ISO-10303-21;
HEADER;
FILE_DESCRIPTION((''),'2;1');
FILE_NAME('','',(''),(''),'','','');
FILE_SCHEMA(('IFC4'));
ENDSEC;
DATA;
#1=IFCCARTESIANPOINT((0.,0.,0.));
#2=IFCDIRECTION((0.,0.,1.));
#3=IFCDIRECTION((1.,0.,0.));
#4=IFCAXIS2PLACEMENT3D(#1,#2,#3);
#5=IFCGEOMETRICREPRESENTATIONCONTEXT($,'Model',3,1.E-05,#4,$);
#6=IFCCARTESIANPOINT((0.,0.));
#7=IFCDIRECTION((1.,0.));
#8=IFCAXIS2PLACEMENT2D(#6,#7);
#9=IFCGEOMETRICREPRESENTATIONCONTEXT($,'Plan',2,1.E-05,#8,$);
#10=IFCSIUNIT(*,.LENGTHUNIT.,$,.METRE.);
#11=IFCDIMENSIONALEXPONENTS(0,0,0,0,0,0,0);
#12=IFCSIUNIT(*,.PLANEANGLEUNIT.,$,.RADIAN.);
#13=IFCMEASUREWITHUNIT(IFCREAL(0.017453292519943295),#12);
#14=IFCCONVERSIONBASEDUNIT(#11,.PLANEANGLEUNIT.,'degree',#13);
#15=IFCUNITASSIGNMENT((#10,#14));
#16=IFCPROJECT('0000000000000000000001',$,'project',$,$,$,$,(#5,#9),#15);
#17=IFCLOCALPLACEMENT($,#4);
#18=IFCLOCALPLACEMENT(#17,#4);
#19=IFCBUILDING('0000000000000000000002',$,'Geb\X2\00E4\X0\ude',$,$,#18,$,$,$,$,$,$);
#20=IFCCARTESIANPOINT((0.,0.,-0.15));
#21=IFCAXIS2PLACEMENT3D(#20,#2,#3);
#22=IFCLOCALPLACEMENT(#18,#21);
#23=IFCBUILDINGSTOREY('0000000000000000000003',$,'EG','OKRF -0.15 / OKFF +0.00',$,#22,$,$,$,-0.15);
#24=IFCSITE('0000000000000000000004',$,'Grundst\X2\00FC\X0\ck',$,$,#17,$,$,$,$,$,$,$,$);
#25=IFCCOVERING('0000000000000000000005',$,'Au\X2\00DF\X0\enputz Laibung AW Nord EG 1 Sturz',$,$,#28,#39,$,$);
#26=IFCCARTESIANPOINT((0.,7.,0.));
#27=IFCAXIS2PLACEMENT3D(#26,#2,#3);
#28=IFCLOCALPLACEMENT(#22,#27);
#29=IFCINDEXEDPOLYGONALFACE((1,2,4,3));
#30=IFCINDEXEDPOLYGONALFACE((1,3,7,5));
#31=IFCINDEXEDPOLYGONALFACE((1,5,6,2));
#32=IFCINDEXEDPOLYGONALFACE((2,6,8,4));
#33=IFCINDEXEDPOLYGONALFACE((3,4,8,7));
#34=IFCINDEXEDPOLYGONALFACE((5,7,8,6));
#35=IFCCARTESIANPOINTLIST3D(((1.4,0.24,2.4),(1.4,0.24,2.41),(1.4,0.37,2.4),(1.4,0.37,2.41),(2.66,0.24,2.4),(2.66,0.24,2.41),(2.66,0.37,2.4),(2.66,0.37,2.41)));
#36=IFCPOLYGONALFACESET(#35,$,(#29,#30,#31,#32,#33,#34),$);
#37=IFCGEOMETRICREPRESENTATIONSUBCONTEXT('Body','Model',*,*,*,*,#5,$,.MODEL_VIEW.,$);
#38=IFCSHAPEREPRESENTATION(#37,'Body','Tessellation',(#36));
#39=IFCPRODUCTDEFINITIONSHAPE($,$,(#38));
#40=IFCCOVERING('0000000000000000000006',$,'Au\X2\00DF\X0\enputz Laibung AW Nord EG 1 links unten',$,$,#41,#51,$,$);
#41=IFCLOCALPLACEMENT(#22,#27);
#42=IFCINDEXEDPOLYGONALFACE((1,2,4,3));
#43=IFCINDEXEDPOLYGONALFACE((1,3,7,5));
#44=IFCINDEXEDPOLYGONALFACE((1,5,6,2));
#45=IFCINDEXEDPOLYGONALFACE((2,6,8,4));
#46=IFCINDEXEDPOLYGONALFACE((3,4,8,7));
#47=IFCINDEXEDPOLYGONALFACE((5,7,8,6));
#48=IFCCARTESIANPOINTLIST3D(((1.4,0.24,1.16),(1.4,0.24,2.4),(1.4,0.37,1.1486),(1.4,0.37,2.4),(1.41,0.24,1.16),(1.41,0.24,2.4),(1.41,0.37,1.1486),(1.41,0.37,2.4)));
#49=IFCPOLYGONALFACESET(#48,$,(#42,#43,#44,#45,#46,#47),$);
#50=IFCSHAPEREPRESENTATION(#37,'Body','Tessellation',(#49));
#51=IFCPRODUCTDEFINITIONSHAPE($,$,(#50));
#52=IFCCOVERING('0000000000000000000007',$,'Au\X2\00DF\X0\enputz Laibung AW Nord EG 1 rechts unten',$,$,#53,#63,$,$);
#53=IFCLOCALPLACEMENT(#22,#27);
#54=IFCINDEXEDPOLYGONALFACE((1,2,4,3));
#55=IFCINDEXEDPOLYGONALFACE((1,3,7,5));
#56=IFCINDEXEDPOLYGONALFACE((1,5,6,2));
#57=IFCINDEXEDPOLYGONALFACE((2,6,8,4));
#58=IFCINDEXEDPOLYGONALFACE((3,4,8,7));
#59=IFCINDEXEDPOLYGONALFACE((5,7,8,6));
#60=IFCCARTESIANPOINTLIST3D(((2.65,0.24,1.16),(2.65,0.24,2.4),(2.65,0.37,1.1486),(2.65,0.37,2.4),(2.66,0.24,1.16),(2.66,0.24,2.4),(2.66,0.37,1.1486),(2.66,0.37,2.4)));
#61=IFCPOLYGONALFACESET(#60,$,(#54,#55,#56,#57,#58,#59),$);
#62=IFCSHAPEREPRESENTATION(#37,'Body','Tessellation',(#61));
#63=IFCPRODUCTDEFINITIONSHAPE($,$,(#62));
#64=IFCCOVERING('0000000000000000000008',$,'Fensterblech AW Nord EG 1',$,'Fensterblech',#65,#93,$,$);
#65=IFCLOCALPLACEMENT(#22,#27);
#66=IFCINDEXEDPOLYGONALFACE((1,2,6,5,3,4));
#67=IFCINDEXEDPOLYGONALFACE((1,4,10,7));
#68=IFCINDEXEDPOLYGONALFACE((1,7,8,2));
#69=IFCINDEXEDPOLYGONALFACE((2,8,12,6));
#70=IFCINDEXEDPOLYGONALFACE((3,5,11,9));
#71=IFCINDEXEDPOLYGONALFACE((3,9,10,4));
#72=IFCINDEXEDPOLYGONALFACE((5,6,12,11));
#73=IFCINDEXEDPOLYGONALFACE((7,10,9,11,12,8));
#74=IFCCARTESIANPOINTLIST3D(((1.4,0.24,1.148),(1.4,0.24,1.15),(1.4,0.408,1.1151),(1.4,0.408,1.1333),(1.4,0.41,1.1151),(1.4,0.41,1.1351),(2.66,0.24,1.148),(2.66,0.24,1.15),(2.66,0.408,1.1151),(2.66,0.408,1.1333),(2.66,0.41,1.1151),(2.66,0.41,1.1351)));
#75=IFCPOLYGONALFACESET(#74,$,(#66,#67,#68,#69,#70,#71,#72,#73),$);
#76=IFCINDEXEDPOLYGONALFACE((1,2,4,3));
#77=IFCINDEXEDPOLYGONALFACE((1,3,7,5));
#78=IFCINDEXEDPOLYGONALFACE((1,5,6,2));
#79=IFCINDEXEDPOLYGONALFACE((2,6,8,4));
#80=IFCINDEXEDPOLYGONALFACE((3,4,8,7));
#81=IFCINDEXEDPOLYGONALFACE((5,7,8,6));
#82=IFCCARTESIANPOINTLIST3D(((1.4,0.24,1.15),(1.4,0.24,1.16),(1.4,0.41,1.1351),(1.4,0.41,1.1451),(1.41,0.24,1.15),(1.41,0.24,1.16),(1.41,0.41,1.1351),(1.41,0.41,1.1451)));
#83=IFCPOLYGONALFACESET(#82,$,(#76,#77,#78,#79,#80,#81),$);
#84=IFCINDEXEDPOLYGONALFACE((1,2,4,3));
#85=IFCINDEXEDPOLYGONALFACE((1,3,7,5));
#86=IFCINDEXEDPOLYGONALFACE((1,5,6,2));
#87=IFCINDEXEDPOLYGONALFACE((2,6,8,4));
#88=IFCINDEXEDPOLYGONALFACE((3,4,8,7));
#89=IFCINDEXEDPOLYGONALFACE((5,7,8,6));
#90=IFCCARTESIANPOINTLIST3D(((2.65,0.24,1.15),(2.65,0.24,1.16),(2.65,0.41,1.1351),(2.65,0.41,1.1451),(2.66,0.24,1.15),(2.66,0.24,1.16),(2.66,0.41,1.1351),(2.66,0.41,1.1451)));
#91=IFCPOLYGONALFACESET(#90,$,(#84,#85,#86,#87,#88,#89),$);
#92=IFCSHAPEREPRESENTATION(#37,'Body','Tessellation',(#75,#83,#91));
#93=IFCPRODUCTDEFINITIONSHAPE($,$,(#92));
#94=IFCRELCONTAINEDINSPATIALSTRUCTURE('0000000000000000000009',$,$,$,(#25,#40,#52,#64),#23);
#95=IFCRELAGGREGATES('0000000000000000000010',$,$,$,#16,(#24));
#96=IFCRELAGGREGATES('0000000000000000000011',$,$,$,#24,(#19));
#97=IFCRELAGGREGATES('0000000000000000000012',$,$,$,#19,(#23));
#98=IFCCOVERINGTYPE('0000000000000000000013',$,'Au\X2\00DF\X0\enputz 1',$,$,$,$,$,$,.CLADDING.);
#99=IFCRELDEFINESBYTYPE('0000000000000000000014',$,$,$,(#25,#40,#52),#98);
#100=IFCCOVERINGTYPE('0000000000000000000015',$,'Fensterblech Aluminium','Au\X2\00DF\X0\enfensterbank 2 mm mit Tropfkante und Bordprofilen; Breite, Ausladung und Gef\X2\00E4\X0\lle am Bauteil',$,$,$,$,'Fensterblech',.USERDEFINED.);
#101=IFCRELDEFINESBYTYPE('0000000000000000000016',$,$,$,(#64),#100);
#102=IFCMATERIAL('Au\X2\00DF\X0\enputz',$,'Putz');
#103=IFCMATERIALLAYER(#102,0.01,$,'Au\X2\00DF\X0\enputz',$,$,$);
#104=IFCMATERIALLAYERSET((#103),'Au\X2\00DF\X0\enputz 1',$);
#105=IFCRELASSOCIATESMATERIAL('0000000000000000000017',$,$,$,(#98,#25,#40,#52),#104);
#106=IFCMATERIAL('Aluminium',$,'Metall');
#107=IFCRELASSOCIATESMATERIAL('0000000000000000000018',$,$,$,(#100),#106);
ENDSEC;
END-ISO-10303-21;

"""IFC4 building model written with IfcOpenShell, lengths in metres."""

from ifc_helpers import new_model, entity, si_unit, converted_unit, frame, origin_with_axes, origin_2d_with_axis, place, context, subcontext, project, spatial, polyline, outline, extrude, material, layer, layer_set, layer_usage, type_object, element, save


model = new_model("IFC4")

# Units and contexts
model_context = context("Model", 3, precision=1e-05, world=origin_with_axes())
plan_context = context("Plan", 2, precision=1e-05, world=origin_2d_with_axis())
body_context_1 = subcontext(model_context, "Body", "Model", "MODEL_VIEW")
ifc_project = project(units=[si_unit("LENGTHUNIT", "METRE"), converted_unit("PLANEANGLEUNIT", "degree", entity("IfcReal", 0.017453292519943295), si_unit("PLANEANGLEUNIT", "RADIAN"), dimensions=[0, 0, 0, 0, 0, 0, 0])], contexts=[model_context, plan_context])

# Site, building, storey
site_placement = place(None, origin_with_axes())
site = spatial("IfcSite", under=ifc_project, at=site_placement, Name="Grundstück")
building_placement = place(site_placement, origin_with_axes())
building = spatial("IfcBuilding", under=site, at=building_placement, Name="Gebäude")
storey_placement = place(building_placement, frame((0.0, 0.0, -0.15), z_axis=(0.0, 0.0, 1.0), x_axis=(1.0, 0.0, 0.0)))
storey = spatial("IfcBuildingStorey", under=building, at=storey_placement, Name="EG", Description="OKRF -0.15 / OKFF +0.00", Elevation=-0.15)

# Coverings
ifc_material_1 = material(Name="Außenputz", Category="Putz")
ifc_layer_1 = layer(ifc_material_1, 0.01, Name="Außenputz")
ifc_layer_set_1 = layer_set([ifc_layer_1], Name="Außenputz 1")
ifc_layer_usage_1 = layer_usage(ifc_layer_set_1, "AXIS3", "POSITIVE", 2.4)
covering_type_1 = type_object("IfcCoveringType", Name="Außenputz 1", PredefinedType="CLADDING", material=ifc_layer_set_1)
covering_1_placement = place(storey_placement, frame((0.0, 7.0, 0.0), z_axis=(0.0, 0.0, 1.0), x_axis=(1.0, 0.0, 0.0)))
element("IfcCovering", 1, at=covering_1_placement, inside=storey, type_object=covering_type_1, material=ifc_layer_usage_1, Name="Außenputz Laibung AW Nord EG 1 Sturz", context=body_context_1, shape_type="SweptSolid", body=[
    extrude(outline(polyline([(0.24, 2.4), (0.37, 2.4), (0.37, 2.41), (0.24, 2.41), (0.24, 2.4)])), frame((1.4, 0.0, 0.0), z_axis=(1.0, 0.0, 0.0), x_axis=(0.0, 1.0, 0.0)), (0.0, 0.0, 1.0), 1.26),
])
ifc_layer_usage_2 = layer_usage(ifc_layer_set_1, "AXIS1", "POSITIVE", 1.4)
covering_2_placement = place(storey_placement, frame((0.0, 7.0, 0.0), z_axis=(0.0, 0.0, 1.0), x_axis=(1.0, 0.0, 0.0)))
element("IfcCovering", 2, at=covering_2_placement, inside=storey, type_object=covering_type_1, material=ifc_layer_usage_2, Name="Außenputz Laibung AW Nord EG 1 links unten", context=body_context_1, shape_type="SweptSolid", body=[
    extrude(outline(polyline([(0.24, 1.16), (0.37, 1.1486), (0.37, 2.4), (0.24, 2.4), (0.24, 1.16)])), frame((1.4, 0.0, 0.0), z_axis=(1.0, 0.0, 0.0), x_axis=(0.0, 1.0, 0.0)), (0.0, 0.0, 1.0), 0.01),
])
ifc_layer_usage_3 = layer_usage(ifc_layer_set_1, "AXIS1", "POSITIVE", 2.65)
covering_3_placement = place(storey_placement, frame((0.0, 7.0, 0.0), z_axis=(0.0, 0.0, 1.0), x_axis=(1.0, 0.0, 0.0)))
element("IfcCovering", 3, at=covering_3_placement, inside=storey, type_object=covering_type_1, material=ifc_layer_usage_3, Name="Außenputz Laibung AW Nord EG 1 rechts unten", context=body_context_1, shape_type="SweptSolid", body=[
    extrude(outline(polyline([(0.24, 1.16), (0.37, 1.1486), (0.37, 2.4), (0.24, 2.4), (0.24, 1.16)])), frame((2.65, 0.0, 0.0), z_axis=(1.0, 0.0, 0.0), x_axis=(0.0, 1.0, 0.0)), (0.0, 0.0, 1.0), 0.01),
])

# Covering
ifc_material_2 = material(Name="Aluminium", Category="Metall")
covering_type_2 = type_object("IfcCoveringType", Name="Fensterblech Aluminium", Description="Außenfensterbank 2 mm mit Tropfkante und Bordprofilen; Breite, Ausladung und Gefälle am Bauteil", ElementType="Fensterblech", PredefinedType="USERDEFINED", material=ifc_material_2)
covering_4_placement = place(storey_placement, frame((0.0, 7.0, 0.0), z_axis=(0.0, 0.0, 1.0), x_axis=(1.0, 0.0, 0.0)))
element("IfcCovering", 4, at=covering_4_placement, inside=storey, type_object=covering_type_2, Name="Fensterblech AW Nord EG 1", ObjectType="Fensterblech", context=body_context_1, shape_type="SweptSolid", body=[
    extrude(outline(polyline([(0.24, 1.148), (0.408, 1.1333), (0.408, 1.1151), (0.41, 1.1151), (0.41, 1.1351), (0.24, 1.15), (0.24, 1.148)])), frame((1.4, 0.0, 0.0), z_axis=(1.0, 0.0, 0.0), x_axis=(0.0, 1.0, 0.0)), (0.0, 0.0, 1.0), 1.26),
    extrude(outline(polyline([(0.24, 1.15), (0.41, 1.1351), (0.41, 1.1451), (0.24, 1.16), (0.24, 1.15)])), frame((1.4, 0.0, 0.0), z_axis=(1.0, 0.0, 0.0), x_axis=(0.0, 1.0, 0.0)), (0.0, 0.0, 1.0), 0.01),
    extrude(outline(polyline([(0.24, 1.15), (0.41, 1.1351), (0.41, 1.1451), (0.24, 1.16), (0.24, 1.15)])), frame((2.65, 0.0, 0.0), z_axis=(1.0, 0.0, 0.0), x_axis=(0.0, 1.0, 0.0)), (0.0, 0.0, 1.0), 0.01),
])

save(model, "model.ifc")
